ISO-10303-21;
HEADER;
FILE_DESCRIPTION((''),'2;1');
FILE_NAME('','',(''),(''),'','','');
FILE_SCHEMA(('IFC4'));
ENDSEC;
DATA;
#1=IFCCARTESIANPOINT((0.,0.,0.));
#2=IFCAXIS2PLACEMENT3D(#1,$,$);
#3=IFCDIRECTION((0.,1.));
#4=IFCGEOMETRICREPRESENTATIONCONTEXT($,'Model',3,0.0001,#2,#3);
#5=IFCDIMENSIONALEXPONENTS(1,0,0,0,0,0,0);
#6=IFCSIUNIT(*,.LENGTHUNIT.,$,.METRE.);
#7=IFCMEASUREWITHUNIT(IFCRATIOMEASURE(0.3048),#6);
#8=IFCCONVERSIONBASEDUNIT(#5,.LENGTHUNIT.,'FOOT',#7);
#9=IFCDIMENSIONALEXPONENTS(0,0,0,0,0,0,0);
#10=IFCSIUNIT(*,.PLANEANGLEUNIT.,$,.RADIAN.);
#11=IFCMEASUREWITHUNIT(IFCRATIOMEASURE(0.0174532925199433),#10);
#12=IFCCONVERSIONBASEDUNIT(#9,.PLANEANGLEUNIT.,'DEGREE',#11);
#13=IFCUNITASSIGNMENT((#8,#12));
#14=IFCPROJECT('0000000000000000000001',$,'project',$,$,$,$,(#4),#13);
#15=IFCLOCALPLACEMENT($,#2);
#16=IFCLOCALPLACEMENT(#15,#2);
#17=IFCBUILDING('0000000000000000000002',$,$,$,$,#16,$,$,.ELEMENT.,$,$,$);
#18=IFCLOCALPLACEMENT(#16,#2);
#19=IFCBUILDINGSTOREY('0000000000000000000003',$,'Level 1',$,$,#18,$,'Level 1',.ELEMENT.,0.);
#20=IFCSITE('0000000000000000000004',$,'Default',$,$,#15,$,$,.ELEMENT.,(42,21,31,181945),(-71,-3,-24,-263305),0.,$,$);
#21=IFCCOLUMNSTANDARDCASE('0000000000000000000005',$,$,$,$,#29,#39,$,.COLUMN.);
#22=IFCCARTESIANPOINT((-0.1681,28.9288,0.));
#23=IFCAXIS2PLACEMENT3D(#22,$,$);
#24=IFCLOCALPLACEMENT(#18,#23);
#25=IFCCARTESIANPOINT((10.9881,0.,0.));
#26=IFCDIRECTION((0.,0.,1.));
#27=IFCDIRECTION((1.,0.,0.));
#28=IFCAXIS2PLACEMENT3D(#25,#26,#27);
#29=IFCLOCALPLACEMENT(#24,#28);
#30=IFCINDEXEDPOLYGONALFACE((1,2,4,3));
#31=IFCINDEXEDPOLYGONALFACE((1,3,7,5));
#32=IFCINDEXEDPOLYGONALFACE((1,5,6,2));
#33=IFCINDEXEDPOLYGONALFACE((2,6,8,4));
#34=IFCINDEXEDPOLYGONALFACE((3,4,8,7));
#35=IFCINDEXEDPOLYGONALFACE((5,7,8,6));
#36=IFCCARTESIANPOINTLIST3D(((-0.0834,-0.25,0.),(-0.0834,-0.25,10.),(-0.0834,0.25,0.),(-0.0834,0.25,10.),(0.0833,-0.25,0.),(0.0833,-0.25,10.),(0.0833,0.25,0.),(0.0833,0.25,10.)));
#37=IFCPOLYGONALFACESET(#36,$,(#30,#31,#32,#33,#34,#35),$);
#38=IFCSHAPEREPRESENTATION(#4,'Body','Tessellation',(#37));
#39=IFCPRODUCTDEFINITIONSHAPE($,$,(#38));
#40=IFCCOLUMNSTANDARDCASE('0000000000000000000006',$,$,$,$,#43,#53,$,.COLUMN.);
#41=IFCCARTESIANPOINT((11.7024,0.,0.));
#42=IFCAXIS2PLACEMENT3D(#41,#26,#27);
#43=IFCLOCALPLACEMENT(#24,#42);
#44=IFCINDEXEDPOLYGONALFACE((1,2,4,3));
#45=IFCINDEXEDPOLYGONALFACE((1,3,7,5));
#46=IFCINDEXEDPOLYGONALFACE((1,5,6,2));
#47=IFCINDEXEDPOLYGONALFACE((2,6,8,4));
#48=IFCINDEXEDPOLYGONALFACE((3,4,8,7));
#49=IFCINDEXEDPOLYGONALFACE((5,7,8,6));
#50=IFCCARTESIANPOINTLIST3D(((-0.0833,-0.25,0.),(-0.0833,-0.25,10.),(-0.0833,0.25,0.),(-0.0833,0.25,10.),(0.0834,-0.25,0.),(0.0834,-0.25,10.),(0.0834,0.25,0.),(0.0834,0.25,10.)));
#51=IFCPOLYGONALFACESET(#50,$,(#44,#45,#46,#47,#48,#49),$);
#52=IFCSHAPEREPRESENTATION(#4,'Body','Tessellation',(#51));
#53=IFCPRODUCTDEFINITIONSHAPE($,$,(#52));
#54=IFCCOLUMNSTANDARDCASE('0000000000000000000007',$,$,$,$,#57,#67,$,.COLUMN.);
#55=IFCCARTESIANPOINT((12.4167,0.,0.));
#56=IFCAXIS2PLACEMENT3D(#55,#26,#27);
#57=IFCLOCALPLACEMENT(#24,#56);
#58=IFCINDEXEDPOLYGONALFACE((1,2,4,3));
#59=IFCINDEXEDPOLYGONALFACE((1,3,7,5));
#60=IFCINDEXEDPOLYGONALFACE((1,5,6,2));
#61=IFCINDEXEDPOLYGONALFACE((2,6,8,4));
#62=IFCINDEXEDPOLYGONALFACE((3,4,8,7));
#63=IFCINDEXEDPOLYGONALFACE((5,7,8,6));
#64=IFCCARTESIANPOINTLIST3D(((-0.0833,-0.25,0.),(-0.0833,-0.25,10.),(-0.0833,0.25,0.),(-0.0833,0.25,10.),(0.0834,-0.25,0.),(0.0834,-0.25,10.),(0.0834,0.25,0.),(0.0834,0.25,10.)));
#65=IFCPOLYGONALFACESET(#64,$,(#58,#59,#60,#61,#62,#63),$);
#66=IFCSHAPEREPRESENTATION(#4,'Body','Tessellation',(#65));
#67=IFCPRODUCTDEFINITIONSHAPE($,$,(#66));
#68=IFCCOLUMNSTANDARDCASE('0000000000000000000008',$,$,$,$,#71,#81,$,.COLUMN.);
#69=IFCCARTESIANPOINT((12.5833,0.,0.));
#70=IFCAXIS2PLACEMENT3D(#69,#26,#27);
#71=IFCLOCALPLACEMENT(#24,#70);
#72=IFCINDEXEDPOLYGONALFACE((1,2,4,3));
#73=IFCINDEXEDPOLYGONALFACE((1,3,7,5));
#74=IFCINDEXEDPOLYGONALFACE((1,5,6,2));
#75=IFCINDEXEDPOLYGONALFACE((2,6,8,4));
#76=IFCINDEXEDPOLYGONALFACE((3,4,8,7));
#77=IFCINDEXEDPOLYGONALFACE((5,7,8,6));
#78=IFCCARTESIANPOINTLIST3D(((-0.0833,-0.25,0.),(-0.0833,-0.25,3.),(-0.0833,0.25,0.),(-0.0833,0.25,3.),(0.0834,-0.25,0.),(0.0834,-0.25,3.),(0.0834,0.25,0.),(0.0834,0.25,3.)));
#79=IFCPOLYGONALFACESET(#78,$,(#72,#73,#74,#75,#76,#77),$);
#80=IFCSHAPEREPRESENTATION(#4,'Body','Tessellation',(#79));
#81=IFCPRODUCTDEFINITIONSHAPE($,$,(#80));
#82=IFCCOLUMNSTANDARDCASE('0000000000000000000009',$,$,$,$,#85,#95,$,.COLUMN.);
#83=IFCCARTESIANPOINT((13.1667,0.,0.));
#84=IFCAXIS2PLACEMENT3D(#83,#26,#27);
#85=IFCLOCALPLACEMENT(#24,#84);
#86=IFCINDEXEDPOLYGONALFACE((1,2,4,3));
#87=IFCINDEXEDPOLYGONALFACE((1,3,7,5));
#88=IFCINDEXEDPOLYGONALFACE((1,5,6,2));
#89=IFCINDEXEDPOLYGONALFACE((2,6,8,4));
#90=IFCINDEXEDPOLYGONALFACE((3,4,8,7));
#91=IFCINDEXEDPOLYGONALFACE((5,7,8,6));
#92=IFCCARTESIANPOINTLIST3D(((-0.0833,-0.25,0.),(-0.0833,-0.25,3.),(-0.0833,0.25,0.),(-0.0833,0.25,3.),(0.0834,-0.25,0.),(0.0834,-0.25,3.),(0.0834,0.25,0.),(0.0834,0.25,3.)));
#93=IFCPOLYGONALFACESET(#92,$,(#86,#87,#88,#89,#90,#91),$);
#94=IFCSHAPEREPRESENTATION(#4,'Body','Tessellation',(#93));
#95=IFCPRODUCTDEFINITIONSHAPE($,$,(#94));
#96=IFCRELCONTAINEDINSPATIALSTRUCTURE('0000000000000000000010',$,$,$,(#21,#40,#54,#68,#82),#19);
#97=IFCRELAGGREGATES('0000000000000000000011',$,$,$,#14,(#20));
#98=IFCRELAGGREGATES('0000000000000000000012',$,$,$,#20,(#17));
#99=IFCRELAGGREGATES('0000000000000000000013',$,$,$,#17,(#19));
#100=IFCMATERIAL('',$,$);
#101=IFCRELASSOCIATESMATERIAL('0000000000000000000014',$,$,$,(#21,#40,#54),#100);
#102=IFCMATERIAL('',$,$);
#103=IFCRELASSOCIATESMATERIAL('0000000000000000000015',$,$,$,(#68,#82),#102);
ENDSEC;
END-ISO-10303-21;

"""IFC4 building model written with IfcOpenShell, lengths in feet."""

from ifc_helpers import new_model, entity, si_unit, converted_unit, direction, frame, origin, place, context, project, spatial, rectangle, extrude, material, element, save


model = new_model("IFC4")

# Units and contexts
model_context = context("Model", 3, precision=0.0001, world=origin(), true_north=direction((0.0, 1.0)))
ifc_project = project(units=[converted_unit("LENGTHUNIT", "FOOT", entity("IfcRatioMeasure", 0.3048), si_unit("LENGTHUNIT", "METRE"), dimensions=[1, 0, 0, 0, 0, 0, 0]), converted_unit("PLANEANGLEUNIT", "DEGREE", entity("IfcRatioMeasure", 0.0174532925199433), si_unit("PLANEANGLEUNIT", "RADIAN"), dimensions=[0, 0, 0, 0, 0, 0, 0])], contexts=[model_context])

# Site, building, storey
site_placement = place(None, origin())
site = spatial("IfcSite", under=ifc_project, at=site_placement, Name="Default", CompositionType="ELEMENT", RefLatitude=(42, 21, 31, 181945), RefLongitude=(-71, -3, -24, -263305), RefElevation=0.0)
building_placement = place(site_placement, origin())
building = spatial("IfcBuilding", under=site, at=building_placement, CompositionType="ELEMENT")
storey_placement = place(building_placement, origin())
storey = spatial("IfcBuildingStorey", under=building, at=storey_placement, Name="Level 1", LongName="Level 1", CompositionType="ELEMENT", Elevation=0.0)

# Columns
ifc_material_1 = material(Name="")
placement = place(storey_placement, frame((-0.1681, 28.9288, 0.0)))
for number, where, z_axis, x_axis in (
    (1, (10.9881, 0.0, 0.0), (0.0, 0.0, 1.0), (1.0, 0.0, 0.0)),
    (2, (11.7024, 0.0, 0.0), (0.0, 0.0, 1.0), (1.0, 0.0, 0.0)),
    (3, (12.4167, 0.0, 0.0), (0.0, 0.0, 1.0), (1.0, 0.0, 0.0)),
):
    element("IfcColumnStandardCase", number, at=place(placement, frame(where, z_axis=z_axis, x_axis=x_axis)), inside=storey, material=ifc_material_1, PredefinedType="COLUMN", context=model_context, shape_type="SweptSolid", body=[
        extrude(rectangle(XDim=0.1667, YDim=0.5), origin(), (0.0, 0.0, 1.0), 10.0),
    ])
ifc_material_2 = material(Name="")
for number, where, z_axis, x_axis in (
    (4, (12.5833, 0.0, 0.0), (0.0, 0.0, 1.0), (1.0, 0.0, 0.0)),
    (5, (13.1667, 0.0, 0.0), (0.0, 0.0, 1.0), (1.0, 0.0, 0.0)),
):
    element("IfcColumnStandardCase", number, at=place(placement, frame(where, z_axis=z_axis, x_axis=x_axis)), inside=storey, material=ifc_material_2, PredefinedType="COLUMN", context=model_context, shape_type="SweptSolid", body=[
        extrude(rectangle(XDim=0.1667, YDim=0.5), origin(), (0.0, 0.0, 1.0), 3.0),
    ])

save(model, "model.ifc")
